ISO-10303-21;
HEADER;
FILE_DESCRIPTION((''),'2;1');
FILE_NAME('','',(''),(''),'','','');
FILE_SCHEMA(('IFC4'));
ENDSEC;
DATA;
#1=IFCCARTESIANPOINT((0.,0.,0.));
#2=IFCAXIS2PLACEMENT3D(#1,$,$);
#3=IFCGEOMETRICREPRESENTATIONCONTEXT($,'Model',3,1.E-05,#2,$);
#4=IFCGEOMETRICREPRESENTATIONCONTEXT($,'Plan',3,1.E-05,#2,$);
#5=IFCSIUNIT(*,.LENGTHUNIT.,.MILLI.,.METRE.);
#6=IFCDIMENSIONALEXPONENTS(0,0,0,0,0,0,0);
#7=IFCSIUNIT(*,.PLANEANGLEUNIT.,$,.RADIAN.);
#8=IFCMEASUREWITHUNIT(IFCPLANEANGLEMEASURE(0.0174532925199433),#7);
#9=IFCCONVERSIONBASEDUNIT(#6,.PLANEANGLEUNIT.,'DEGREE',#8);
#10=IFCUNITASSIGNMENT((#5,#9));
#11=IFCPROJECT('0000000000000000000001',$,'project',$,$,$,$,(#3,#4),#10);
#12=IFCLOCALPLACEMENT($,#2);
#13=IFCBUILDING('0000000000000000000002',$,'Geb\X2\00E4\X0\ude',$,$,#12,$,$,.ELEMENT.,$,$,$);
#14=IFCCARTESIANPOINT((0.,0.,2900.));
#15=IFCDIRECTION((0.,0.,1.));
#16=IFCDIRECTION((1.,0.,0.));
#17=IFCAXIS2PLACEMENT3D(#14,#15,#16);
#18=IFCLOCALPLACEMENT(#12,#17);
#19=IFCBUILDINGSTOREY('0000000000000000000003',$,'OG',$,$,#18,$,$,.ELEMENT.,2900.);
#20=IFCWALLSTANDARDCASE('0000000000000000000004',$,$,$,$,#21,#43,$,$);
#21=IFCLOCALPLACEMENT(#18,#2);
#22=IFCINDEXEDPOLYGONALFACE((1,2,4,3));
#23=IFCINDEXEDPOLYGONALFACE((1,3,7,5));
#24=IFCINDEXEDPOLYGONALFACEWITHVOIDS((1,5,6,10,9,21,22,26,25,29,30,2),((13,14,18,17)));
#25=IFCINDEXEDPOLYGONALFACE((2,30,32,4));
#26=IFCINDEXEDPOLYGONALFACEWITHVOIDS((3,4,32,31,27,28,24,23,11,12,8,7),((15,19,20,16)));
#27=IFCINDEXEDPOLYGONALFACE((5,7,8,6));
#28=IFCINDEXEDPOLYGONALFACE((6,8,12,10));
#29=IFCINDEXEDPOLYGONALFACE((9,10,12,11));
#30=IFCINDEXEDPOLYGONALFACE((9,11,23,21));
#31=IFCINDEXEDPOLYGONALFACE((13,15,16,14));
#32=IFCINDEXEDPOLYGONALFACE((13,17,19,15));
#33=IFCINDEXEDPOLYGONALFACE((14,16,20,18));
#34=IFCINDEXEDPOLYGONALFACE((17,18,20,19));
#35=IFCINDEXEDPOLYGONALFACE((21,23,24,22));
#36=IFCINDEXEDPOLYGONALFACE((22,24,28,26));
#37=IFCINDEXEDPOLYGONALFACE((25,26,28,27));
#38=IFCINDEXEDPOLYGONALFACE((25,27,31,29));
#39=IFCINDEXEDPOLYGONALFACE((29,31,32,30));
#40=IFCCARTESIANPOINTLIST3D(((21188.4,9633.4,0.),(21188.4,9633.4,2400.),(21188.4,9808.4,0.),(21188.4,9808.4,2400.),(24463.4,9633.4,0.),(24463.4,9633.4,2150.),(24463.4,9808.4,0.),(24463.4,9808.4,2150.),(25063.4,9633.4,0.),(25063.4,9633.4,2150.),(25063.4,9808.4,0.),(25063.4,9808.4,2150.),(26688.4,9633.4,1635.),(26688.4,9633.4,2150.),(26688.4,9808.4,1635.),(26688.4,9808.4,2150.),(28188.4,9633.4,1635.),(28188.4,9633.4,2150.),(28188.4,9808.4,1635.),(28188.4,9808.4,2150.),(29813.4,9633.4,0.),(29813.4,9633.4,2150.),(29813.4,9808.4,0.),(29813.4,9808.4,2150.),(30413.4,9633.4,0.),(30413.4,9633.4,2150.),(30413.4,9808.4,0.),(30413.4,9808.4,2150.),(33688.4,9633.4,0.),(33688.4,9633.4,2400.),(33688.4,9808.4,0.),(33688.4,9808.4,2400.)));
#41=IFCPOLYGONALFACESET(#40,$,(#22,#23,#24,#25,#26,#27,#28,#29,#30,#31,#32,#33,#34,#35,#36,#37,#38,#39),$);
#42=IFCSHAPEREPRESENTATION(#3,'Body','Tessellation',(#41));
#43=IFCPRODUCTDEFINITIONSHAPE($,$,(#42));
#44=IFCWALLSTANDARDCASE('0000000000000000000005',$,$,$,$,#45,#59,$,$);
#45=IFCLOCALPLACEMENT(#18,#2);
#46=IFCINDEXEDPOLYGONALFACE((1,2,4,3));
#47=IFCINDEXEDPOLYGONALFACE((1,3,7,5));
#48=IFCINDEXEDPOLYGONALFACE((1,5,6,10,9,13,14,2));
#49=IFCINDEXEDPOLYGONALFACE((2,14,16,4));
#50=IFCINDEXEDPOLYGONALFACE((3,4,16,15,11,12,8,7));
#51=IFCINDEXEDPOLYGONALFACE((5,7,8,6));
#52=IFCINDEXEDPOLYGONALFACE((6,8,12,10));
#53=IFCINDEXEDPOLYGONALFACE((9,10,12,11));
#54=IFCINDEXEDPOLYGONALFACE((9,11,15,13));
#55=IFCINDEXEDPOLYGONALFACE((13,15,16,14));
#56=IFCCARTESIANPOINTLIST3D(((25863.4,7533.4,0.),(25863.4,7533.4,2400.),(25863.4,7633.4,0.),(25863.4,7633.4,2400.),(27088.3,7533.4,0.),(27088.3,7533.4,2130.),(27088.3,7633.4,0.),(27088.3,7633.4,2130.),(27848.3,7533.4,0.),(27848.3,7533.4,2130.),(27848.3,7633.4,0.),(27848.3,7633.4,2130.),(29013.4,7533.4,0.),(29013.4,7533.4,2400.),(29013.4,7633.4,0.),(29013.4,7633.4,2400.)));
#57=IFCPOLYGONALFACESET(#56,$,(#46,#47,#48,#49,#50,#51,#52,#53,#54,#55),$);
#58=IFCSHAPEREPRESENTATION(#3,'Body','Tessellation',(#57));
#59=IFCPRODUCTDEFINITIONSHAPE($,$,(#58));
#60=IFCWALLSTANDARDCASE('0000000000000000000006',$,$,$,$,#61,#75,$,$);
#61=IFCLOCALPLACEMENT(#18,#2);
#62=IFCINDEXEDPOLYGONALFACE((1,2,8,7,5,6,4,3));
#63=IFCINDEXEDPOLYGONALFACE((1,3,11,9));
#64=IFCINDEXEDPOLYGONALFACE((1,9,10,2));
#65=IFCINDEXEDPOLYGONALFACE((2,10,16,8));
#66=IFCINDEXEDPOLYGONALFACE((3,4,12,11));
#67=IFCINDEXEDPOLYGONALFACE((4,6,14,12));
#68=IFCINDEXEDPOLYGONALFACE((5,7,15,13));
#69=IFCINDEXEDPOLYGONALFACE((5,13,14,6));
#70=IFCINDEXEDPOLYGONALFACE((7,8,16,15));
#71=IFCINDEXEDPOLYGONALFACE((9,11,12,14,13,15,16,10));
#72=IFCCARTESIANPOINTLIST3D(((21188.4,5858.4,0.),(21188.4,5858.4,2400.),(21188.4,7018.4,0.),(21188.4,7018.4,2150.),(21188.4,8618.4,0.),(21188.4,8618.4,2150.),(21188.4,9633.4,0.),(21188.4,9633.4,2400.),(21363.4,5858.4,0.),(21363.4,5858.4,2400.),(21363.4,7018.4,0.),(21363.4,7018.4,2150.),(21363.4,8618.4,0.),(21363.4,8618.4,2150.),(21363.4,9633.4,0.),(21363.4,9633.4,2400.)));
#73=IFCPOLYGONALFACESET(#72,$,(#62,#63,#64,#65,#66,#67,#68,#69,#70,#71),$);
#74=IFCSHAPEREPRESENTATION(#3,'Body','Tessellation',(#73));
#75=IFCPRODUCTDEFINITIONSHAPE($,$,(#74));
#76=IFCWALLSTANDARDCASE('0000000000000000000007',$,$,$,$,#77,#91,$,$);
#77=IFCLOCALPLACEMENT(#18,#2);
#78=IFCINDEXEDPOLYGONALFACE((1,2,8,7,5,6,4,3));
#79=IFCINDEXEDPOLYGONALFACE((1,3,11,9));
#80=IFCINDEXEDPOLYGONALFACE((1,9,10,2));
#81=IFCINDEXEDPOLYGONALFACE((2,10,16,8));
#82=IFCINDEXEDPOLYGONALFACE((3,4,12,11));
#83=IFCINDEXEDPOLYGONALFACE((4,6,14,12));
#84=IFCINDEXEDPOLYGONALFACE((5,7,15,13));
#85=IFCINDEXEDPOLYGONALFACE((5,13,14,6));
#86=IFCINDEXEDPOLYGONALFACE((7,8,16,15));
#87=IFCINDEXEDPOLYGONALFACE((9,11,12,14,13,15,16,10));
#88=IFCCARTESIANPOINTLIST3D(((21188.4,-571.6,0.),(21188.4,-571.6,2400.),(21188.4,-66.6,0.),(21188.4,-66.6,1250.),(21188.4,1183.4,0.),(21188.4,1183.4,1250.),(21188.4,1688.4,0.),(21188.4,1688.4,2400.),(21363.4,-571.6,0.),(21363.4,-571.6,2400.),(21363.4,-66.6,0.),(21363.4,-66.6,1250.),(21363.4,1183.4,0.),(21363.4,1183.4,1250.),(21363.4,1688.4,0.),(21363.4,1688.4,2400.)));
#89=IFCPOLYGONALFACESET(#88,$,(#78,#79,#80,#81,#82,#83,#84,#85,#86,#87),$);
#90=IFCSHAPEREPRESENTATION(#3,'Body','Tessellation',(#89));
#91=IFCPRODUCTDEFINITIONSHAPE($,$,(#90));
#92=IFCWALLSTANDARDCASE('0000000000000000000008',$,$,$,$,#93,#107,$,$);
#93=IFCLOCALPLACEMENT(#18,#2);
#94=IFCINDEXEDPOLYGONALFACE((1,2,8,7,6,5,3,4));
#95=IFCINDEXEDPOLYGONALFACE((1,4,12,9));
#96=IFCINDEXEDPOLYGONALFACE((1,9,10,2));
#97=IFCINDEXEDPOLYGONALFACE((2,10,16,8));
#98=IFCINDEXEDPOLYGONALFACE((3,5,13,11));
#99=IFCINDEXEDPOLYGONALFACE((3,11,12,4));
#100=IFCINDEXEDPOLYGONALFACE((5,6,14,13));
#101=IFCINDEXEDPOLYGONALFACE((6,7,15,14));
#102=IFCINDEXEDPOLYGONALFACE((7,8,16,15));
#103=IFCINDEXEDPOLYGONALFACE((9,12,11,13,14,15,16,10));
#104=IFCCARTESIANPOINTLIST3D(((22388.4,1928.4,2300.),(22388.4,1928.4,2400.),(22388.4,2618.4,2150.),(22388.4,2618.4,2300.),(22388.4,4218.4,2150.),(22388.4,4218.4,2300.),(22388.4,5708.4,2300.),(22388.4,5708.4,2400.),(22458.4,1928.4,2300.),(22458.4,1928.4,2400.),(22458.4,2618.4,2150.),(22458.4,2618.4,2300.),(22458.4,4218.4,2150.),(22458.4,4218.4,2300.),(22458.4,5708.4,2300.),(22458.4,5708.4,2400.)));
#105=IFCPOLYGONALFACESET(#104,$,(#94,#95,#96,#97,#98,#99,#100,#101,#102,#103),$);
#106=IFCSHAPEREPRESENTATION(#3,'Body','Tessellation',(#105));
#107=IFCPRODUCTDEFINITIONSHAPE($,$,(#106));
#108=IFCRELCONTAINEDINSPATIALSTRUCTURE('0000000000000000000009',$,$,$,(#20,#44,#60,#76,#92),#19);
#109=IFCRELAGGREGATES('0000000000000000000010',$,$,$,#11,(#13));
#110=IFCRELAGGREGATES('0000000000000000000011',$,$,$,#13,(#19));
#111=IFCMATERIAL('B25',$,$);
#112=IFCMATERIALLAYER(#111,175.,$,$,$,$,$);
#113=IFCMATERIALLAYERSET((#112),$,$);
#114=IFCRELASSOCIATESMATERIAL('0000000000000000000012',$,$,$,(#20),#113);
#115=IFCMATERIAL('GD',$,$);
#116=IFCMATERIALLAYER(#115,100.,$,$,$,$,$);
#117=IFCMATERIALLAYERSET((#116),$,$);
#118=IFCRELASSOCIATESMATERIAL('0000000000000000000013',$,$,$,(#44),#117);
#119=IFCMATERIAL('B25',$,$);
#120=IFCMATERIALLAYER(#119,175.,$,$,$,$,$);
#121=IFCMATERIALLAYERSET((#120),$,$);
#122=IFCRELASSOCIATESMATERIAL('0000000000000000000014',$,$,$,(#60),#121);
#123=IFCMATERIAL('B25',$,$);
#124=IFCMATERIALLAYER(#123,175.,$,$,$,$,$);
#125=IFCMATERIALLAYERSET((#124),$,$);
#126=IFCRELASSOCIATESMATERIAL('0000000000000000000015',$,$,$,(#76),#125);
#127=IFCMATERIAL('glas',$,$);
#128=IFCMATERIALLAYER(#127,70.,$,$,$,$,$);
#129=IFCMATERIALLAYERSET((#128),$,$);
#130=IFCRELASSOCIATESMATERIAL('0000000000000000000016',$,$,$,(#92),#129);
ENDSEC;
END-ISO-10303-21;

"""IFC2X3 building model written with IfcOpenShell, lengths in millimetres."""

from ifc_helpers import new_model, entity, si_unit, converted_unit, frame, frame_2d, origin, origin_with_axes, place, context, project, spatial, rectangle, extrude, material, layer, layer_set, layer_usage, element, save


model = new_model("IFC2X3")

# Units and contexts
model_context = context("Model", 3, precision=1e-05, world=origin())
plan_context = context("Plan", 3, precision=1e-05, world=origin())
ifc_project = project(units=[si_unit("LENGTHUNIT", "METRE", prefix="MILLI"), converted_unit("PLANEANGLEUNIT", "DEGREE", entity("IfcPlaneAngleMeasure", 0.0174532925199433), si_unit("PLANEANGLEUNIT", "RADIAN"), dimensions=[0, 0, 0, 0, 0, 0, 0])], contexts=[model_context, plan_context])

# Building, storey
building_placement = place(None, origin())
building = spatial("IfcBuilding", under=ifc_project, at=building_placement, Name="Gebäude", CompositionType="ELEMENT")
storey_placement = place(building_placement, frame((0.0, 0.0, 2900.0), z_axis=(0.0, 0.0, 1.0), x_axis=(1.0, 0.0, 0.0)))
storey = spatial("IfcBuildingStorey", under=building, at=storey_placement, Name="OG", CompositionType="ELEMENT", Elevation=2900.0)

# Wall, openings
ifc_material_1 = material(Name="B25")
ifc_layer_1 = layer(ifc_material_1, 175.0)
ifc_layer_set_1 = layer_set([ifc_layer_1])
ifc_layer_usage_1 = layer_usage(ifc_layer_set_1, "AXIS2", "POSITIVE", 0.0)
wall_1_placement = place(storey_placement, frame((33688.4, 9808.4, 0.0), z_axis=(0.0, 0.0, 1.0), x_axis=(-1.0, 0.0, 0.0)))
wall_1 = element("IfcWallStandardCase", 1, at=wall_1_placement, inside=storey, material=ifc_layer_usage_1, context=model_context, shape_type="SweptSolid", body=[
    extrude(rectangle(XDim=12500.0, YDim=175.0, at=frame_2d((6250.0, 87.5), x_axis=(1.0, 0.0))), origin_with_axes(), (0.0, 0.0, 1.0), 2400.0),
])
opening_1_placement = place(wall_1_placement, frame((3275.0, 0.0, 0.0), z_axis=(0.0, 1.0, 0.0), x_axis=(0.0, 0.0, 1.0)))
element("IfcOpeningElement", 2, at=opening_1_placement, cuts=wall_1, ObjectType="Opening", context=model_context, shape_type="SweptSolid", body=[
    extrude(rectangle(XDim=2150.0, YDim=600.0, at=frame_2d((1075.0, 300.0), x_axis=(1.0, 0.0))), origin_with_axes(), (0.0, 0.0, 1.0), 175.0),
])
opening_2_placement = place(wall_1_placement, frame((5500.0, 0.0, 1635.0), z_axis=(0.0, 1.0, 0.0), x_axis=(0.0, 0.0, 1.0)))
element("IfcOpeningElement", 3, at=opening_2_placement, cuts=wall_1, ObjectType="Opening", context=model_context, shape_type="SweptSolid", body=[
    extrude(rectangle(XDim=515.0, YDim=1500.0, at=frame_2d((257.5, 750.0), x_axis=(1.0, 0.0))), origin_with_axes(), (0.0, 0.0, 1.0), 175.0),
])
opening_3_placement = place(wall_1_placement, frame((8625.0, 0.0, 0.0), z_axis=(0.0, 1.0, 0.0), x_axis=(0.0, 0.0, 1.0)))
element("IfcOpeningElement", 4, at=opening_3_placement, cuts=wall_1, ObjectType="Opening", context=model_context, shape_type="SweptSolid", body=[
    extrude(rectangle(XDim=2150.0, YDim=600.0, at=frame_2d((1075.0, 300.0), x_axis=(1.0, 0.0))), origin_with_axes(), (0.0, 0.0, 1.0), 175.0),
])

# Walls, openings
ifc_material_2 = material(Name="GD")
ifc_layer_2 = layer(ifc_material_2, 100.0)
ifc_layer_set_2 = layer_set([ifc_layer_2])
ifc_layer_usage_2 = layer_usage(ifc_layer_set_2, "AXIS2", "POSITIVE", 0.0)
wall_2_placement = place(storey_placement, frame((25863.4, 7533.4, 0.0), z_axis=(0.0, 0.0, 1.0), x_axis=(1.0, 0.0, 0.0)))
wall_2 = element("IfcWallStandardCase", 5, at=wall_2_placement, inside=storey, material=ifc_layer_usage_2, context=model_context, shape_type="SweptSolid", body=[
    extrude(rectangle(XDim=3150.0, YDim=100.0, at=frame_2d((1575.0, 50.0), x_axis=(1.0, 0.0))), origin_with_axes(), (0.0, 0.0, 1.0), 2400.0),
])
opening_4_placement = place(wall_2_placement, frame((1225.0, 0.0, 0.0), z_axis=(0.0, 1.0, 0.0), x_axis=(0.0, 0.0, 1.0)))
element("IfcOpeningElement", 6, at=opening_4_placement, cuts=wall_2, ObjectType="Opening", context=model_context, shape_type="SweptSolid", body=[
    extrude(rectangle(XDim=2130.0, YDim=760.0, at=frame_2d((1065.0, 380.0), x_axis=(1.0, 0.0))), origin_with_axes(), (0.0, 0.0, 1.0), 100.0),
])
ifc_material_3 = material(Name="B25")
ifc_layer_3 = layer(ifc_material_3, 175.0)
ifc_layer_set_3 = layer_set([ifc_layer_3])
ifc_layer_usage_3 = layer_usage(ifc_layer_set_3, "AXIS2", "POSITIVE", 0.0)
wall_3_placement = place(storey_placement, frame((21188.4, 9633.4, 0.0), z_axis=(0.0, 0.0, 1.0), x_axis=(0.0, -1.0, 0.0)))
wall_3 = element("IfcWallStandardCase", 7, at=wall_3_placement, inside=storey, material=ifc_layer_usage_3, context=model_context, shape_type="SweptSolid", body=[
    extrude(rectangle(XDim=3775.0, YDim=175.0, at=frame_2d((1887.5, 87.5), x_axis=(1.0, 0.0))), origin_with_axes(), (0.0, 0.0, 1.0), 2400.0),
])
opening_5_placement = place(wall_3_placement, frame((1015.0, 0.0, 0.0), z_axis=(0.0, 1.0, 0.0), x_axis=(0.0, 0.0, 1.0)))
element("IfcOpeningElement", 8, at=opening_5_placement, cuts=wall_3, ObjectType="Opening", context=model_context, shape_type="SweptSolid", body=[
    extrude(rectangle(XDim=2150.0, YDim=1600.0, at=frame_2d((1075.0, 800.0), x_axis=(1.0, 0.0))), origin_with_axes(), (0.0, 0.0, 1.0), 175.0),
])
ifc_material_4 = material(Name="B25")
ifc_layer_4 = layer(ifc_material_4, 175.0)
ifc_layer_set_4 = layer_set([ifc_layer_4])
ifc_layer_usage_4 = layer_usage(ifc_layer_set_4, "AXIS2", "POSITIVE", 0.0)
wall_4_placement = place(storey_placement, frame((21188.4, 1688.4, 0.0), z_axis=(0.0, 0.0, 1.0), x_axis=(0.0, -1.0, 0.0)))
wall_4 = element("IfcWallStandardCase", 9, at=wall_4_placement, inside=storey, material=ifc_layer_usage_4, context=model_context, shape_type="SweptSolid", body=[
    extrude(rectangle(XDim=2260.0, YDim=175.0, at=frame_2d((1130.0, 87.5), x_axis=(1.0, 0.0))), origin_with_axes(), (0.0, 0.0, 1.0), 2400.0),
])
opening_6_placement = place(wall_4_placement, frame((505.0, 0.0, 0.0), z_axis=(0.0, 1.0, 0.0), x_axis=(0.0, 0.0, 1.0)))
element("IfcOpeningElement", 10, at=opening_6_placement, cuts=wall_4, ObjectType="Opening", context=model_context, shape_type="SweptSolid", body=[
    extrude(rectangle(XDim=1250.0, YDim=1250.0, at=frame_2d((625.0, 625.0), x_axis=(1.0, 0.0))), origin_with_axes(), (0.0, 0.0, 1.0), 175.0),
])

# Wall, openings
ifc_material_5 = material(Name="glas")
ifc_layer_5 = layer(ifc_material_5, 70.0)
ifc_layer_set_5 = layer_set([ifc_layer_5])
ifc_layer_usage_5 = layer_usage(ifc_layer_set_5, "AXIS2", "POSITIVE", 0.0)
wall_5_placement = place(storey_placement, frame((22458.4, 1928.4, 0.0), z_axis=(0.0, 0.0, 1.0), x_axis=(0.0, 1.0, 0.0)))
wall_5 = element("IfcWallStandardCase", 11, at=wall_5_placement, inside=storey, material=ifc_layer_usage_5, context=model_context, shape_type="SweptSolid", body=[
    extrude(rectangle(XDim=3780.0, YDim=70.0, at=frame_2d((1890.0, 35.0), x_axis=(1.0, 0.0))), origin_with_axes(), (0.0, 0.0, 1.0), 2400.0),
])
opening_7_placement = place(wall_5_placement, frame((2290.0, 0.0, 0.0), z_axis=(0.0, 1.0, 0.0), x_axis=(0.0, 0.0, 1.0)))
element("IfcOpeningElement", 12, at=opening_7_placement, cuts=wall_5, ObjectType="Opening", context=model_context, shape_type="SweptSolid", body=[
    extrude(rectangle(XDim=2300.0, YDim=1490.0, at=frame_2d((1150.0, 745.0), x_axis=(1.0, 0.0))), origin_with_axes(), (0.0, 0.0, 1.0), 70.0),
])
opening_8_placement = place(wall_5_placement, frame((0.0, 0.0, 0.0), z_axis=(0.0, 1.0, 0.0), x_axis=(0.0, 0.0, 1.0)))
element("IfcOpeningElement", 13, at=opening_8_placement, cuts=wall_5, ObjectType="Opening", context=model_context, shape_type="SweptSolid", body=[
    extrude(rectangle(XDim=2300.0, YDim=690.0, at=frame_2d((1150.0, 345.0), x_axis=(1.0, 0.0))), origin_with_axes(), (0.0, 0.0, 1.0), 70.0),
])
opening_9_placement = place(wall_5_placement, frame((690.0, 0.0, 0.0), z_axis=(0.0, 1.0, 0.0), x_axis=(0.0, 0.0, 1.0)))
element("IfcOpeningElement", 14, at=opening_9_placement, cuts=wall_5, ObjectType="Opening", context=model_context, shape_type="SweptSolid", body=[
    extrude(rectangle(XDim=2150.0, YDim=1600.0, at=frame_2d((1075.0, 800.0), x_axis=(1.0, 0.0))), origin_with_axes(), (0.0, 0.0, 1.0), 70.0),
])

save(model, "model.ifc")
